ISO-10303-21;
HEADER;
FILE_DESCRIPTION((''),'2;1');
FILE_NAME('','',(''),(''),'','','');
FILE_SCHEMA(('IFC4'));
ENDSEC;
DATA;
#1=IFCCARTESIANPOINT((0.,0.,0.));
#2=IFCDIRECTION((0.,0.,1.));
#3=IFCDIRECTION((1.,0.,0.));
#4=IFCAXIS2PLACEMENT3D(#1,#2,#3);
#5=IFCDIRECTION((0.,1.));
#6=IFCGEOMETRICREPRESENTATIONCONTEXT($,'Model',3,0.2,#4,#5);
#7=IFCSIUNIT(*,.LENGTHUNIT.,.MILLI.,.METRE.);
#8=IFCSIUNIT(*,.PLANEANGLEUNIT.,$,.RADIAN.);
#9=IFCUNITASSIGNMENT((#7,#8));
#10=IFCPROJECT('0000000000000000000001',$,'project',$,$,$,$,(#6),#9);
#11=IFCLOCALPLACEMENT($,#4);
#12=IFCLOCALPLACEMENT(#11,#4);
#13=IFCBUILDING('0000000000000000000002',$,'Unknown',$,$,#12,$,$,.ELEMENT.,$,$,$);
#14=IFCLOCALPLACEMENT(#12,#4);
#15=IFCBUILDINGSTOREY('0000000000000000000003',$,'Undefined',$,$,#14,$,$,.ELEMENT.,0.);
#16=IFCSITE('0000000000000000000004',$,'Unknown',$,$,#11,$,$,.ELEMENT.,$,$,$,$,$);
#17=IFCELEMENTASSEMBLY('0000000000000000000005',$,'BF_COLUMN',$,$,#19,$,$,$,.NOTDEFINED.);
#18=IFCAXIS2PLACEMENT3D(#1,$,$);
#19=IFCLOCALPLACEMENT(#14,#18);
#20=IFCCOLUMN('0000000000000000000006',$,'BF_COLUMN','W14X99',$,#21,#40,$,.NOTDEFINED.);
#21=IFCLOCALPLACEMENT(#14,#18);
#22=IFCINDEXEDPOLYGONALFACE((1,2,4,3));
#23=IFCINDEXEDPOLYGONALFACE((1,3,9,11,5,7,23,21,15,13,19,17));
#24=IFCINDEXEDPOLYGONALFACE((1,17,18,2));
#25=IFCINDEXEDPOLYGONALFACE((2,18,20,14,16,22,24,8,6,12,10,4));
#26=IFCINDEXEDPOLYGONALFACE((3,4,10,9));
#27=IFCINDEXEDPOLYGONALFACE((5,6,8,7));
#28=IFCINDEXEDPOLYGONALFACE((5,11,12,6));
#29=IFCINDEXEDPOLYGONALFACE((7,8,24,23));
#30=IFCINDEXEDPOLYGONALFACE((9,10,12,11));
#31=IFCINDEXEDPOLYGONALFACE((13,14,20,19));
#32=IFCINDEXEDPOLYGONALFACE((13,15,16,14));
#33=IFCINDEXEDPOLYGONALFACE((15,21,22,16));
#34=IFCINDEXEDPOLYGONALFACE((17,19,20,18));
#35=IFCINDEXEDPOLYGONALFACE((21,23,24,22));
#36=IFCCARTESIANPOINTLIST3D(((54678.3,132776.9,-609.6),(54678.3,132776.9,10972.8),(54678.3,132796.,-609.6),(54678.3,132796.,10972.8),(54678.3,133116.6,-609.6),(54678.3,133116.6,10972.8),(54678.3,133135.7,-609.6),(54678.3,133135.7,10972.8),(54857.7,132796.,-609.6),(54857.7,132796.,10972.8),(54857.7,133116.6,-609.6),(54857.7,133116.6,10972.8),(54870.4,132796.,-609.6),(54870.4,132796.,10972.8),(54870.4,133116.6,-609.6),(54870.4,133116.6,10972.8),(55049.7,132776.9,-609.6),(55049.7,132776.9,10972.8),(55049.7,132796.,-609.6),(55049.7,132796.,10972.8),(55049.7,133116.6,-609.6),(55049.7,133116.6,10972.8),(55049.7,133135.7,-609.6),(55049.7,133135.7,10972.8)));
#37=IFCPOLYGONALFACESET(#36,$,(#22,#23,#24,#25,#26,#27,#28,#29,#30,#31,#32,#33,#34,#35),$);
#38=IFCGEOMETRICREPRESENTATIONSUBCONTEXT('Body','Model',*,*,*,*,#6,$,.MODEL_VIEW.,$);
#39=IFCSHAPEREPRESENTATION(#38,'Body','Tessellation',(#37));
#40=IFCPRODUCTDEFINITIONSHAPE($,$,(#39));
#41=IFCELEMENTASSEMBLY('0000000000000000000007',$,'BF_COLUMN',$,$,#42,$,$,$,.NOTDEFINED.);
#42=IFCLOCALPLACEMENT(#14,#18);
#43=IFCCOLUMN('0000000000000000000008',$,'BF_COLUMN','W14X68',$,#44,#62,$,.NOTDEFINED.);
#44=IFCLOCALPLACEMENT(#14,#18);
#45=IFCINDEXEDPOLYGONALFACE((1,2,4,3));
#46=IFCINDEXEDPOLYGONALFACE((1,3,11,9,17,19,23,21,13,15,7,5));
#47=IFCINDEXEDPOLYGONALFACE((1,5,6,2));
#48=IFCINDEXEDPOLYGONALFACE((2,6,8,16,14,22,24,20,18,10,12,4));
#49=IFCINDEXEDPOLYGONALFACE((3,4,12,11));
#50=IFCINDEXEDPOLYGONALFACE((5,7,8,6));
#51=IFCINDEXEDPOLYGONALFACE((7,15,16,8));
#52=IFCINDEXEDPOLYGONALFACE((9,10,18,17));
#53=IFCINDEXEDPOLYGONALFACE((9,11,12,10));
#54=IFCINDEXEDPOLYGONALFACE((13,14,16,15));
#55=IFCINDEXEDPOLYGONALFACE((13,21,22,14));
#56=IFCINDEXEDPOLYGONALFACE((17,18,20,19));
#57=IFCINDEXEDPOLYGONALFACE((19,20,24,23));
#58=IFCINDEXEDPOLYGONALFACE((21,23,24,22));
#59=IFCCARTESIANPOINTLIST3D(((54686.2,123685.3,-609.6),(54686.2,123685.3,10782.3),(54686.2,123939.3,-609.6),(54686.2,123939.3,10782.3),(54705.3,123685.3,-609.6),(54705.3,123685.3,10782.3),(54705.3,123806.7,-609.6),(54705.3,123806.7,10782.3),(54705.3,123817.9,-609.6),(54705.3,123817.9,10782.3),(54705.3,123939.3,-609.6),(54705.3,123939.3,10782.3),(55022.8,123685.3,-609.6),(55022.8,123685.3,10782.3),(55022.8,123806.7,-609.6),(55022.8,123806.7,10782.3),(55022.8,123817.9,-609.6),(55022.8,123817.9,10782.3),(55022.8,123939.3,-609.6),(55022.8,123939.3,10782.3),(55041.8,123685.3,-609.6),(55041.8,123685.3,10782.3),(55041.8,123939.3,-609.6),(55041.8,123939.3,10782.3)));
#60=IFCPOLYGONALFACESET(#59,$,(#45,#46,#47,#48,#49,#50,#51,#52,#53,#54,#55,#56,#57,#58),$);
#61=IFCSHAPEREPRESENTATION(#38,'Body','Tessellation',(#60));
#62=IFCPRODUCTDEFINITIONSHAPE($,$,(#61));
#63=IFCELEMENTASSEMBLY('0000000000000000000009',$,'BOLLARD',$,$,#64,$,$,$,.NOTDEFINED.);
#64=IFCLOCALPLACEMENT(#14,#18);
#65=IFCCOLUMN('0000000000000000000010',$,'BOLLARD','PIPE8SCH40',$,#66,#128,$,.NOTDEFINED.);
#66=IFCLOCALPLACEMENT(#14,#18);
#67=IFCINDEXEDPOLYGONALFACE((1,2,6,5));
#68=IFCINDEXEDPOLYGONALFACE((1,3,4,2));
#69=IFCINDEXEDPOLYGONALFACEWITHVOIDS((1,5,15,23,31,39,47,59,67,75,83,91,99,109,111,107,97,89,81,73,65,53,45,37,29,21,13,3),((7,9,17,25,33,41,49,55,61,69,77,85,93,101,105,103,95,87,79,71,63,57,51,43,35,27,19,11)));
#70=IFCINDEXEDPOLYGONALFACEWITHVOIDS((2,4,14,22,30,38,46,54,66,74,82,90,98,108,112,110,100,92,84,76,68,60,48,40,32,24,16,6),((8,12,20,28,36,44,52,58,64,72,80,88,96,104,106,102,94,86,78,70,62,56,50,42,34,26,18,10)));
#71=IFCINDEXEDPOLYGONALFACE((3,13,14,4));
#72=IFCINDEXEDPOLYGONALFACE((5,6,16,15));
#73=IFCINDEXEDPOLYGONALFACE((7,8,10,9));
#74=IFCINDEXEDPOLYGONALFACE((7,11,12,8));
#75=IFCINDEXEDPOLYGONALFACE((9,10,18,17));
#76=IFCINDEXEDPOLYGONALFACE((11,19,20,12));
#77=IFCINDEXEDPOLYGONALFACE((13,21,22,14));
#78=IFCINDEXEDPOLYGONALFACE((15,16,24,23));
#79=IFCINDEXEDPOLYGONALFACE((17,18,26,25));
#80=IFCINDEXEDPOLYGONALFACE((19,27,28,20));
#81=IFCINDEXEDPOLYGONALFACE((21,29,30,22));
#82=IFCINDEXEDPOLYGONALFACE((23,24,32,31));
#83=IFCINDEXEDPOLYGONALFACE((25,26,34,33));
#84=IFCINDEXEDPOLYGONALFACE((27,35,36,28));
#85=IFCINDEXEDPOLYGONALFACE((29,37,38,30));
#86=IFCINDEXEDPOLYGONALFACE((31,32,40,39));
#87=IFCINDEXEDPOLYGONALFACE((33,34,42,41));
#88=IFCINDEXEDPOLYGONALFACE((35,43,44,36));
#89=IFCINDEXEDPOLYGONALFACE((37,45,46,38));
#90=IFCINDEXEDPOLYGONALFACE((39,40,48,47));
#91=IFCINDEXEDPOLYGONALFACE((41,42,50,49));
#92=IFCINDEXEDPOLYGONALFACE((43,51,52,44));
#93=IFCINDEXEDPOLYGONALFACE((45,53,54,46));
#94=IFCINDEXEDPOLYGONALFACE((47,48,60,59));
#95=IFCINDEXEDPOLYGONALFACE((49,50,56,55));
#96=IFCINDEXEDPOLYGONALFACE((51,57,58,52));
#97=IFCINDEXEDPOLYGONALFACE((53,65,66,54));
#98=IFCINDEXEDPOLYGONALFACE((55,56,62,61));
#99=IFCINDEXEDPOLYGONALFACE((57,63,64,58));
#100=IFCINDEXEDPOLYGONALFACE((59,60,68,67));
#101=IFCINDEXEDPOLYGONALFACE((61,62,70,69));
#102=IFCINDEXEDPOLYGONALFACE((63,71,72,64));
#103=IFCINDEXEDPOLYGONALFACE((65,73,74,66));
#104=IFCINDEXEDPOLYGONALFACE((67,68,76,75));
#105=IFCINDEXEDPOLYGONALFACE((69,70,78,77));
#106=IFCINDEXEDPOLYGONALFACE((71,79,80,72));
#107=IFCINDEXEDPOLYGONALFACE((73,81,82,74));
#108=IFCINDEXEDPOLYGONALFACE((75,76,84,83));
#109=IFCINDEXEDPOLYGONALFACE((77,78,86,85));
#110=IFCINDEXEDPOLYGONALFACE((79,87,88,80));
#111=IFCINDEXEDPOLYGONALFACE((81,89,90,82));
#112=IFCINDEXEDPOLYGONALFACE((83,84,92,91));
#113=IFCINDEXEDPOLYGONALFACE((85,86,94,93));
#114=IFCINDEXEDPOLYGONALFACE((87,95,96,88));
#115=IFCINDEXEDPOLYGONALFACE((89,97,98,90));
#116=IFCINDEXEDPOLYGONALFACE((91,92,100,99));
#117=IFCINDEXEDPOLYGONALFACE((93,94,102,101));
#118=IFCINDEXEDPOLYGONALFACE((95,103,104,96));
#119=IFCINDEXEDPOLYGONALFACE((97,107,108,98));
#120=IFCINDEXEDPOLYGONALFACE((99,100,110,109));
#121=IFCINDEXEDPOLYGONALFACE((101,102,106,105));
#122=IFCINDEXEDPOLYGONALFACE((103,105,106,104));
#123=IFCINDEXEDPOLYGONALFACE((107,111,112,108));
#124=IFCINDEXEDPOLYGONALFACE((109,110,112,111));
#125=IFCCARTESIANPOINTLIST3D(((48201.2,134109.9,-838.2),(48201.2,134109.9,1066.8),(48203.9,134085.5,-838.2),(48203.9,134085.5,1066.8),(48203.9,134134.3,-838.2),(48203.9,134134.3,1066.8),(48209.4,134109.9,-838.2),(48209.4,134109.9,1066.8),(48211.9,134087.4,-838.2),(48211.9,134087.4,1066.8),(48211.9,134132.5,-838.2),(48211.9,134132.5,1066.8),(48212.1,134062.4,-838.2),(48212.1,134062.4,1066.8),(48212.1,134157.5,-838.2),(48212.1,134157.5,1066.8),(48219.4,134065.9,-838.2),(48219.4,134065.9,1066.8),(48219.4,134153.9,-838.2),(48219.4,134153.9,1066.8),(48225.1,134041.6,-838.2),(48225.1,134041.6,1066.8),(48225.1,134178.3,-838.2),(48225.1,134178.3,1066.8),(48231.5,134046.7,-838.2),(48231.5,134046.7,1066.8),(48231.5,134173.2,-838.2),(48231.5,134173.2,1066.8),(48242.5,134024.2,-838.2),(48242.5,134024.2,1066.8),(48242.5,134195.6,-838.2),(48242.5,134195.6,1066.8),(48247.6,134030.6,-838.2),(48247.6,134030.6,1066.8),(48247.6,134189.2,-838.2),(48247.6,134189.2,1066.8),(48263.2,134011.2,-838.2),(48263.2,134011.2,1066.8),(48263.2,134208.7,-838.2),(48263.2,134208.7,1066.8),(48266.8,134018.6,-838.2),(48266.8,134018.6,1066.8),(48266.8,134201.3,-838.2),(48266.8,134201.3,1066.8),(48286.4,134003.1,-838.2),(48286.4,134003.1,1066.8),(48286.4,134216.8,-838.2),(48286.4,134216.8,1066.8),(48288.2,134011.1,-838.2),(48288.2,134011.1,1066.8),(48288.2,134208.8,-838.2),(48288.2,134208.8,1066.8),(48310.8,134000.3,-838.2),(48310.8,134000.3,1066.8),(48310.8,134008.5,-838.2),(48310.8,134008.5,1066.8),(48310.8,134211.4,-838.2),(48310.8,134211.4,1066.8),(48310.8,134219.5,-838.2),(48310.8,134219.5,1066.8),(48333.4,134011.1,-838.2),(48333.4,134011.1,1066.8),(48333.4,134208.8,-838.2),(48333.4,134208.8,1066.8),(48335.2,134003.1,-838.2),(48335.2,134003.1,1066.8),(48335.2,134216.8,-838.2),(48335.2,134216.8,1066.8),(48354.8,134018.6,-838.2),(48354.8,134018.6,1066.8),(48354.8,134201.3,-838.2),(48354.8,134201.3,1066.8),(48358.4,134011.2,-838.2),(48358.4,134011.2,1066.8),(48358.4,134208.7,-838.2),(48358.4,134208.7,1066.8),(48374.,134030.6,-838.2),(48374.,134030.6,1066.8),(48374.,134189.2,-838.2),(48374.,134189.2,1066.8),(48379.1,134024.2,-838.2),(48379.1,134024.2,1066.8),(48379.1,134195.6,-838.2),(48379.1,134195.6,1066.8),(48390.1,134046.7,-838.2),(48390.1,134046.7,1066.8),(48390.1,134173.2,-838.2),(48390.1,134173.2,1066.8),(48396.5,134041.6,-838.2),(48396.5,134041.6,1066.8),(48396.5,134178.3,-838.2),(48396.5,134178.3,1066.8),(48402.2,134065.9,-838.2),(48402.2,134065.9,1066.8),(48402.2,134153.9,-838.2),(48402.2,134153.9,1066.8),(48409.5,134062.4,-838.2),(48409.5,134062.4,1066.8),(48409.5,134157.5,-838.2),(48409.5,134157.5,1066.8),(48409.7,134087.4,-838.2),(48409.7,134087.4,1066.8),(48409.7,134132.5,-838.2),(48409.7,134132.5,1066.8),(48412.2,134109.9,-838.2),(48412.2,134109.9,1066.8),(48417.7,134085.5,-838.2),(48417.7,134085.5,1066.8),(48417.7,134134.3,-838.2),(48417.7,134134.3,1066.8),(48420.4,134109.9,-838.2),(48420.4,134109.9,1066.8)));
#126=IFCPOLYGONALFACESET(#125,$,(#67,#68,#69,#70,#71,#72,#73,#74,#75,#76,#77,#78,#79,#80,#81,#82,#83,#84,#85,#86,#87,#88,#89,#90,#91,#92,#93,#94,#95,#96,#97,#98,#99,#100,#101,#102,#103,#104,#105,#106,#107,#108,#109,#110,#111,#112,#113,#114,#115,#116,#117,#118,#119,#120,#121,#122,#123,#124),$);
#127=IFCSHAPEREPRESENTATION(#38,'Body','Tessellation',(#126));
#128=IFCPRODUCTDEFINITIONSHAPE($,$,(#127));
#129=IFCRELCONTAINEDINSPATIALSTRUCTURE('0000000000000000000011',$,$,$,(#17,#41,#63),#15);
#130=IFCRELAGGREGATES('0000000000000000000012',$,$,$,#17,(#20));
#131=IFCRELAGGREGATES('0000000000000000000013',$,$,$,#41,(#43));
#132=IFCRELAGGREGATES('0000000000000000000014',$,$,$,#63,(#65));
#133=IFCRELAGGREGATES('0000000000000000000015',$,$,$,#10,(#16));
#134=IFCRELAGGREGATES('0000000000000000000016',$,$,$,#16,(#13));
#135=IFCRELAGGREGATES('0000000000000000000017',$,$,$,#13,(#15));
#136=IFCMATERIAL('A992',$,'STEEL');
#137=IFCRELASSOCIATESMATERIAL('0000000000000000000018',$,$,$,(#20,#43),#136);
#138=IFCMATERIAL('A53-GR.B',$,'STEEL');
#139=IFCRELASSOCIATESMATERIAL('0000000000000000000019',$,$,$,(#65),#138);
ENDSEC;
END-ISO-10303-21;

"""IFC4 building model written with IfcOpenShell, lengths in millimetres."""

from ifc_helpers import new_model, si_unit, direction, frame, origin_with_axes, place, context, subcontext, project, spatial, line, indexed_curve, outline, extrude, material, element, aggregate, save


model = new_model("IFC4")

# Units and contexts
model_context = context("Model", 3, precision=0.2, world=origin_with_axes(), true_north=direction((0.0, 1.0)))
body_context = subcontext(model_context, "Body", "Model", "MODEL_VIEW")
ifc_project = project(units=[si_unit("LENGTHUNIT", "METRE", prefix="MILLI"), si_unit("PLANEANGLEUNIT", "RADIAN")], contexts=[model_context])

# Site, building, storey
site_placement = place(None, origin_with_axes())
site = spatial("IfcSite", under=ifc_project, at=site_placement, Name="Unknown", CompositionType="ELEMENT")
building_placement = place(site_placement, origin_with_axes())
building = spatial("IfcBuilding", under=site, at=building_placement, Name="Unknown", CompositionType="ELEMENT")
storey_placement = place(building_placement, origin_with_axes())
storey = spatial("IfcBuildingStorey", under=building, at=storey_placement, Name="Undefined", CompositionType="ELEMENT", Elevation=0.0)

# Element assemblies, columns
assembly_1_placement = place(storey_placement, frame((54864.0, 132956.3, -609.6), z_axis=(-1.0, 0.0, 0.0), x_axis=(0.0, 0.0, 1.0)))
assembly_1 = element("IfcElementAssembly", 1, at=assembly_1_placement, inside=storey, Name="BF_COLUMN", PredefinedType="NOTDEFINED")
ifc_material_1 = material(Name="A992", Category="STEEL")
column_1_placement = place(assembly_1_placement, origin_with_axes())
column_1 = element("IfcColumn", 2, at=column_1_placement, material=ifc_material_1, Name="BF_COLUMN", Description="W14X99", PredefinedType="NOTDEFINED", context=body_context, shape_type="SolidModel", body=[
    extrude(outline(indexed_curve([(-185.7, -179.4), (185.7, -179.4), (185.7, -160.3), (6.3, -160.3), (6.3, 160.3), (185.7, 160.3), (185.7, 179.4), (-185.7, 179.4), (-185.7, 160.3), (-6.3, 160.3), (-6.3, -160.3), (-185.7, -160.3)], segments=[line(1, 2, 3, 4, 5, 6, 7, 8, 9, 10, 11, 12, 1)])), frame((0.0, 0.0, 0.0), z_axis=(-1.0, 0.0, 0.0), x_axis=(0.0, 0.0, 1.0)), (0.0, 0.0, -1.0), 11582.4),
])
aggregate(assembly_1, [column_1])
assembly_2_placement = place(storey_placement, frame((54864.0, 123812.3, -609.6), z_axis=(0.0, -1.0, 0.0), x_axis=(0.0, 0.0, 1.0)))
assembly_2 = element("IfcElementAssembly", 3, at=assembly_2_placement, inside=storey, Name="BF_COLUMN", PredefinedType="NOTDEFINED")
column_2_placement = place(assembly_2_placement, origin_with_axes())
column_2 = element("IfcColumn", 4, at=column_2_placement, material=ifc_material_1, Name="BF_COLUMN", Description="W14X68", PredefinedType="NOTDEFINED", context=body_context, shape_type="SolidModel", body=[
    extrude(outline(indexed_curve([(-127.0, -177.8), (127.0, -177.8), (127.0, -158.8), (5.6, -158.8), (5.6, 158.8), (127.0, 158.8), (127.0, 177.8), (-127.0, 177.8), (-127.0, 158.8), (-5.6, 158.8), (-5.6, -158.8), (-127.0, -158.8)], segments=[line(1, 2, 3, 4, 5, 6, 7, 8, 9, 10, 11, 12, 1)])), frame((0.0, 0.0, 0.0), z_axis=(-1.0, 0.0, 0.0), x_axis=(0.0, 0.0, 1.0)), (0.0, 0.0, -1.0), 11391.9),
])
aggregate(assembly_2, [column_2])
assembly_3_placement = place(storey_placement, frame((48310.8, 134109.9, -838.2), z_axis=(-1.0, 0.0, 0.0), x_axis=(0.0, 0.0, 1.0)))
assembly_3 = element("IfcElementAssembly", 5, at=assembly_3_placement, inside=storey, Name="BOLLARD", PredefinedType="NOTDEFINED")
ifc_material_2 = material(Name="A53-GR.B", Category="STEEL")
column_3_placement = place(assembly_3_placement, origin_with_axes())
column_3 = element("IfcColumn", 6, at=column_3_placement, material=ifc_material_2, Name="BOLLARD", Description="PIPE8SCH40", PredefinedType="NOTDEFINED", context=body_context, shape_type="SolidModel", body=[
    extrude(outline(indexed_curve([(109.6, 0.0), (106.9, 24.4), (98.7, 47.6), (85.7, 68.3), (68.3, 85.7), (47.6, 98.7), (24.4, 106.9), (0.0, 109.6), (-24.4, 106.9), (-47.6, 98.7), (-68.3, 85.7), (-85.7, 68.3), (-98.7, 47.6), (-106.9, 24.4), (-109.6, 0.0), (-106.9, -24.4), (-98.7, -47.6), (-85.7, -68.3), (-68.3, -85.7), (-47.6, -98.7), (-24.4, -106.9), (0.0, -109.6), (24.4, -106.9), (47.6, -98.7), (68.3, -85.7), (85.7, -68.3), (98.7, -47.6), (106.9, -24.4)], segments=[line(1, 2, 3, 4, 5, 6, 7, 8, 9, 10, 11, 12, 13, 14, 15, 16, 17, 18, 19, 20, 21, 22, 23, 24, 25, 26, 27, 28, 1)]), holes=[indexed_curve([(101.4, 0.0), (98.9, -22.6), (91.4, -44.0), (79.3, -63.2), (63.2, -79.3), (44.0, -91.4), (22.6, -98.9), (0.0, -101.4), (-22.6, -98.9), (-44.0, -91.4), (-63.2, -79.3), (-79.3, -63.2), (-91.4, -44.0), (-98.9, -22.6), (-101.4, 0.0), (-98.9, 22.6), (-91.4, 44.0), (-79.3, 63.2), (-63.2, 79.3), (-44.0, 91.4), (-22.6, 98.9), (0.0, 101.4), (22.6, 98.9), (44.0, 91.4), (63.2, 79.3), (79.3, 63.2), (91.4, 44.0), (98.9, 22.6)], segments=[line(1, 2, 3, 4, 5, 6, 7, 8, 9, 10, 11, 12, 13, 14, 15, 16, 17, 18, 19, 20, 21, 22, 23, 24, 25, 26, 27, 28, 1)])]), frame((0.0, 0.0, 0.0), z_axis=(-1.0, 0.0, 0.0), x_axis=(0.0, 0.0, 1.0)), (0.0, 0.0, -1.0), 1905.0),
])
aggregate(assembly_3, [column_3])

save(model, "model.ifc")
